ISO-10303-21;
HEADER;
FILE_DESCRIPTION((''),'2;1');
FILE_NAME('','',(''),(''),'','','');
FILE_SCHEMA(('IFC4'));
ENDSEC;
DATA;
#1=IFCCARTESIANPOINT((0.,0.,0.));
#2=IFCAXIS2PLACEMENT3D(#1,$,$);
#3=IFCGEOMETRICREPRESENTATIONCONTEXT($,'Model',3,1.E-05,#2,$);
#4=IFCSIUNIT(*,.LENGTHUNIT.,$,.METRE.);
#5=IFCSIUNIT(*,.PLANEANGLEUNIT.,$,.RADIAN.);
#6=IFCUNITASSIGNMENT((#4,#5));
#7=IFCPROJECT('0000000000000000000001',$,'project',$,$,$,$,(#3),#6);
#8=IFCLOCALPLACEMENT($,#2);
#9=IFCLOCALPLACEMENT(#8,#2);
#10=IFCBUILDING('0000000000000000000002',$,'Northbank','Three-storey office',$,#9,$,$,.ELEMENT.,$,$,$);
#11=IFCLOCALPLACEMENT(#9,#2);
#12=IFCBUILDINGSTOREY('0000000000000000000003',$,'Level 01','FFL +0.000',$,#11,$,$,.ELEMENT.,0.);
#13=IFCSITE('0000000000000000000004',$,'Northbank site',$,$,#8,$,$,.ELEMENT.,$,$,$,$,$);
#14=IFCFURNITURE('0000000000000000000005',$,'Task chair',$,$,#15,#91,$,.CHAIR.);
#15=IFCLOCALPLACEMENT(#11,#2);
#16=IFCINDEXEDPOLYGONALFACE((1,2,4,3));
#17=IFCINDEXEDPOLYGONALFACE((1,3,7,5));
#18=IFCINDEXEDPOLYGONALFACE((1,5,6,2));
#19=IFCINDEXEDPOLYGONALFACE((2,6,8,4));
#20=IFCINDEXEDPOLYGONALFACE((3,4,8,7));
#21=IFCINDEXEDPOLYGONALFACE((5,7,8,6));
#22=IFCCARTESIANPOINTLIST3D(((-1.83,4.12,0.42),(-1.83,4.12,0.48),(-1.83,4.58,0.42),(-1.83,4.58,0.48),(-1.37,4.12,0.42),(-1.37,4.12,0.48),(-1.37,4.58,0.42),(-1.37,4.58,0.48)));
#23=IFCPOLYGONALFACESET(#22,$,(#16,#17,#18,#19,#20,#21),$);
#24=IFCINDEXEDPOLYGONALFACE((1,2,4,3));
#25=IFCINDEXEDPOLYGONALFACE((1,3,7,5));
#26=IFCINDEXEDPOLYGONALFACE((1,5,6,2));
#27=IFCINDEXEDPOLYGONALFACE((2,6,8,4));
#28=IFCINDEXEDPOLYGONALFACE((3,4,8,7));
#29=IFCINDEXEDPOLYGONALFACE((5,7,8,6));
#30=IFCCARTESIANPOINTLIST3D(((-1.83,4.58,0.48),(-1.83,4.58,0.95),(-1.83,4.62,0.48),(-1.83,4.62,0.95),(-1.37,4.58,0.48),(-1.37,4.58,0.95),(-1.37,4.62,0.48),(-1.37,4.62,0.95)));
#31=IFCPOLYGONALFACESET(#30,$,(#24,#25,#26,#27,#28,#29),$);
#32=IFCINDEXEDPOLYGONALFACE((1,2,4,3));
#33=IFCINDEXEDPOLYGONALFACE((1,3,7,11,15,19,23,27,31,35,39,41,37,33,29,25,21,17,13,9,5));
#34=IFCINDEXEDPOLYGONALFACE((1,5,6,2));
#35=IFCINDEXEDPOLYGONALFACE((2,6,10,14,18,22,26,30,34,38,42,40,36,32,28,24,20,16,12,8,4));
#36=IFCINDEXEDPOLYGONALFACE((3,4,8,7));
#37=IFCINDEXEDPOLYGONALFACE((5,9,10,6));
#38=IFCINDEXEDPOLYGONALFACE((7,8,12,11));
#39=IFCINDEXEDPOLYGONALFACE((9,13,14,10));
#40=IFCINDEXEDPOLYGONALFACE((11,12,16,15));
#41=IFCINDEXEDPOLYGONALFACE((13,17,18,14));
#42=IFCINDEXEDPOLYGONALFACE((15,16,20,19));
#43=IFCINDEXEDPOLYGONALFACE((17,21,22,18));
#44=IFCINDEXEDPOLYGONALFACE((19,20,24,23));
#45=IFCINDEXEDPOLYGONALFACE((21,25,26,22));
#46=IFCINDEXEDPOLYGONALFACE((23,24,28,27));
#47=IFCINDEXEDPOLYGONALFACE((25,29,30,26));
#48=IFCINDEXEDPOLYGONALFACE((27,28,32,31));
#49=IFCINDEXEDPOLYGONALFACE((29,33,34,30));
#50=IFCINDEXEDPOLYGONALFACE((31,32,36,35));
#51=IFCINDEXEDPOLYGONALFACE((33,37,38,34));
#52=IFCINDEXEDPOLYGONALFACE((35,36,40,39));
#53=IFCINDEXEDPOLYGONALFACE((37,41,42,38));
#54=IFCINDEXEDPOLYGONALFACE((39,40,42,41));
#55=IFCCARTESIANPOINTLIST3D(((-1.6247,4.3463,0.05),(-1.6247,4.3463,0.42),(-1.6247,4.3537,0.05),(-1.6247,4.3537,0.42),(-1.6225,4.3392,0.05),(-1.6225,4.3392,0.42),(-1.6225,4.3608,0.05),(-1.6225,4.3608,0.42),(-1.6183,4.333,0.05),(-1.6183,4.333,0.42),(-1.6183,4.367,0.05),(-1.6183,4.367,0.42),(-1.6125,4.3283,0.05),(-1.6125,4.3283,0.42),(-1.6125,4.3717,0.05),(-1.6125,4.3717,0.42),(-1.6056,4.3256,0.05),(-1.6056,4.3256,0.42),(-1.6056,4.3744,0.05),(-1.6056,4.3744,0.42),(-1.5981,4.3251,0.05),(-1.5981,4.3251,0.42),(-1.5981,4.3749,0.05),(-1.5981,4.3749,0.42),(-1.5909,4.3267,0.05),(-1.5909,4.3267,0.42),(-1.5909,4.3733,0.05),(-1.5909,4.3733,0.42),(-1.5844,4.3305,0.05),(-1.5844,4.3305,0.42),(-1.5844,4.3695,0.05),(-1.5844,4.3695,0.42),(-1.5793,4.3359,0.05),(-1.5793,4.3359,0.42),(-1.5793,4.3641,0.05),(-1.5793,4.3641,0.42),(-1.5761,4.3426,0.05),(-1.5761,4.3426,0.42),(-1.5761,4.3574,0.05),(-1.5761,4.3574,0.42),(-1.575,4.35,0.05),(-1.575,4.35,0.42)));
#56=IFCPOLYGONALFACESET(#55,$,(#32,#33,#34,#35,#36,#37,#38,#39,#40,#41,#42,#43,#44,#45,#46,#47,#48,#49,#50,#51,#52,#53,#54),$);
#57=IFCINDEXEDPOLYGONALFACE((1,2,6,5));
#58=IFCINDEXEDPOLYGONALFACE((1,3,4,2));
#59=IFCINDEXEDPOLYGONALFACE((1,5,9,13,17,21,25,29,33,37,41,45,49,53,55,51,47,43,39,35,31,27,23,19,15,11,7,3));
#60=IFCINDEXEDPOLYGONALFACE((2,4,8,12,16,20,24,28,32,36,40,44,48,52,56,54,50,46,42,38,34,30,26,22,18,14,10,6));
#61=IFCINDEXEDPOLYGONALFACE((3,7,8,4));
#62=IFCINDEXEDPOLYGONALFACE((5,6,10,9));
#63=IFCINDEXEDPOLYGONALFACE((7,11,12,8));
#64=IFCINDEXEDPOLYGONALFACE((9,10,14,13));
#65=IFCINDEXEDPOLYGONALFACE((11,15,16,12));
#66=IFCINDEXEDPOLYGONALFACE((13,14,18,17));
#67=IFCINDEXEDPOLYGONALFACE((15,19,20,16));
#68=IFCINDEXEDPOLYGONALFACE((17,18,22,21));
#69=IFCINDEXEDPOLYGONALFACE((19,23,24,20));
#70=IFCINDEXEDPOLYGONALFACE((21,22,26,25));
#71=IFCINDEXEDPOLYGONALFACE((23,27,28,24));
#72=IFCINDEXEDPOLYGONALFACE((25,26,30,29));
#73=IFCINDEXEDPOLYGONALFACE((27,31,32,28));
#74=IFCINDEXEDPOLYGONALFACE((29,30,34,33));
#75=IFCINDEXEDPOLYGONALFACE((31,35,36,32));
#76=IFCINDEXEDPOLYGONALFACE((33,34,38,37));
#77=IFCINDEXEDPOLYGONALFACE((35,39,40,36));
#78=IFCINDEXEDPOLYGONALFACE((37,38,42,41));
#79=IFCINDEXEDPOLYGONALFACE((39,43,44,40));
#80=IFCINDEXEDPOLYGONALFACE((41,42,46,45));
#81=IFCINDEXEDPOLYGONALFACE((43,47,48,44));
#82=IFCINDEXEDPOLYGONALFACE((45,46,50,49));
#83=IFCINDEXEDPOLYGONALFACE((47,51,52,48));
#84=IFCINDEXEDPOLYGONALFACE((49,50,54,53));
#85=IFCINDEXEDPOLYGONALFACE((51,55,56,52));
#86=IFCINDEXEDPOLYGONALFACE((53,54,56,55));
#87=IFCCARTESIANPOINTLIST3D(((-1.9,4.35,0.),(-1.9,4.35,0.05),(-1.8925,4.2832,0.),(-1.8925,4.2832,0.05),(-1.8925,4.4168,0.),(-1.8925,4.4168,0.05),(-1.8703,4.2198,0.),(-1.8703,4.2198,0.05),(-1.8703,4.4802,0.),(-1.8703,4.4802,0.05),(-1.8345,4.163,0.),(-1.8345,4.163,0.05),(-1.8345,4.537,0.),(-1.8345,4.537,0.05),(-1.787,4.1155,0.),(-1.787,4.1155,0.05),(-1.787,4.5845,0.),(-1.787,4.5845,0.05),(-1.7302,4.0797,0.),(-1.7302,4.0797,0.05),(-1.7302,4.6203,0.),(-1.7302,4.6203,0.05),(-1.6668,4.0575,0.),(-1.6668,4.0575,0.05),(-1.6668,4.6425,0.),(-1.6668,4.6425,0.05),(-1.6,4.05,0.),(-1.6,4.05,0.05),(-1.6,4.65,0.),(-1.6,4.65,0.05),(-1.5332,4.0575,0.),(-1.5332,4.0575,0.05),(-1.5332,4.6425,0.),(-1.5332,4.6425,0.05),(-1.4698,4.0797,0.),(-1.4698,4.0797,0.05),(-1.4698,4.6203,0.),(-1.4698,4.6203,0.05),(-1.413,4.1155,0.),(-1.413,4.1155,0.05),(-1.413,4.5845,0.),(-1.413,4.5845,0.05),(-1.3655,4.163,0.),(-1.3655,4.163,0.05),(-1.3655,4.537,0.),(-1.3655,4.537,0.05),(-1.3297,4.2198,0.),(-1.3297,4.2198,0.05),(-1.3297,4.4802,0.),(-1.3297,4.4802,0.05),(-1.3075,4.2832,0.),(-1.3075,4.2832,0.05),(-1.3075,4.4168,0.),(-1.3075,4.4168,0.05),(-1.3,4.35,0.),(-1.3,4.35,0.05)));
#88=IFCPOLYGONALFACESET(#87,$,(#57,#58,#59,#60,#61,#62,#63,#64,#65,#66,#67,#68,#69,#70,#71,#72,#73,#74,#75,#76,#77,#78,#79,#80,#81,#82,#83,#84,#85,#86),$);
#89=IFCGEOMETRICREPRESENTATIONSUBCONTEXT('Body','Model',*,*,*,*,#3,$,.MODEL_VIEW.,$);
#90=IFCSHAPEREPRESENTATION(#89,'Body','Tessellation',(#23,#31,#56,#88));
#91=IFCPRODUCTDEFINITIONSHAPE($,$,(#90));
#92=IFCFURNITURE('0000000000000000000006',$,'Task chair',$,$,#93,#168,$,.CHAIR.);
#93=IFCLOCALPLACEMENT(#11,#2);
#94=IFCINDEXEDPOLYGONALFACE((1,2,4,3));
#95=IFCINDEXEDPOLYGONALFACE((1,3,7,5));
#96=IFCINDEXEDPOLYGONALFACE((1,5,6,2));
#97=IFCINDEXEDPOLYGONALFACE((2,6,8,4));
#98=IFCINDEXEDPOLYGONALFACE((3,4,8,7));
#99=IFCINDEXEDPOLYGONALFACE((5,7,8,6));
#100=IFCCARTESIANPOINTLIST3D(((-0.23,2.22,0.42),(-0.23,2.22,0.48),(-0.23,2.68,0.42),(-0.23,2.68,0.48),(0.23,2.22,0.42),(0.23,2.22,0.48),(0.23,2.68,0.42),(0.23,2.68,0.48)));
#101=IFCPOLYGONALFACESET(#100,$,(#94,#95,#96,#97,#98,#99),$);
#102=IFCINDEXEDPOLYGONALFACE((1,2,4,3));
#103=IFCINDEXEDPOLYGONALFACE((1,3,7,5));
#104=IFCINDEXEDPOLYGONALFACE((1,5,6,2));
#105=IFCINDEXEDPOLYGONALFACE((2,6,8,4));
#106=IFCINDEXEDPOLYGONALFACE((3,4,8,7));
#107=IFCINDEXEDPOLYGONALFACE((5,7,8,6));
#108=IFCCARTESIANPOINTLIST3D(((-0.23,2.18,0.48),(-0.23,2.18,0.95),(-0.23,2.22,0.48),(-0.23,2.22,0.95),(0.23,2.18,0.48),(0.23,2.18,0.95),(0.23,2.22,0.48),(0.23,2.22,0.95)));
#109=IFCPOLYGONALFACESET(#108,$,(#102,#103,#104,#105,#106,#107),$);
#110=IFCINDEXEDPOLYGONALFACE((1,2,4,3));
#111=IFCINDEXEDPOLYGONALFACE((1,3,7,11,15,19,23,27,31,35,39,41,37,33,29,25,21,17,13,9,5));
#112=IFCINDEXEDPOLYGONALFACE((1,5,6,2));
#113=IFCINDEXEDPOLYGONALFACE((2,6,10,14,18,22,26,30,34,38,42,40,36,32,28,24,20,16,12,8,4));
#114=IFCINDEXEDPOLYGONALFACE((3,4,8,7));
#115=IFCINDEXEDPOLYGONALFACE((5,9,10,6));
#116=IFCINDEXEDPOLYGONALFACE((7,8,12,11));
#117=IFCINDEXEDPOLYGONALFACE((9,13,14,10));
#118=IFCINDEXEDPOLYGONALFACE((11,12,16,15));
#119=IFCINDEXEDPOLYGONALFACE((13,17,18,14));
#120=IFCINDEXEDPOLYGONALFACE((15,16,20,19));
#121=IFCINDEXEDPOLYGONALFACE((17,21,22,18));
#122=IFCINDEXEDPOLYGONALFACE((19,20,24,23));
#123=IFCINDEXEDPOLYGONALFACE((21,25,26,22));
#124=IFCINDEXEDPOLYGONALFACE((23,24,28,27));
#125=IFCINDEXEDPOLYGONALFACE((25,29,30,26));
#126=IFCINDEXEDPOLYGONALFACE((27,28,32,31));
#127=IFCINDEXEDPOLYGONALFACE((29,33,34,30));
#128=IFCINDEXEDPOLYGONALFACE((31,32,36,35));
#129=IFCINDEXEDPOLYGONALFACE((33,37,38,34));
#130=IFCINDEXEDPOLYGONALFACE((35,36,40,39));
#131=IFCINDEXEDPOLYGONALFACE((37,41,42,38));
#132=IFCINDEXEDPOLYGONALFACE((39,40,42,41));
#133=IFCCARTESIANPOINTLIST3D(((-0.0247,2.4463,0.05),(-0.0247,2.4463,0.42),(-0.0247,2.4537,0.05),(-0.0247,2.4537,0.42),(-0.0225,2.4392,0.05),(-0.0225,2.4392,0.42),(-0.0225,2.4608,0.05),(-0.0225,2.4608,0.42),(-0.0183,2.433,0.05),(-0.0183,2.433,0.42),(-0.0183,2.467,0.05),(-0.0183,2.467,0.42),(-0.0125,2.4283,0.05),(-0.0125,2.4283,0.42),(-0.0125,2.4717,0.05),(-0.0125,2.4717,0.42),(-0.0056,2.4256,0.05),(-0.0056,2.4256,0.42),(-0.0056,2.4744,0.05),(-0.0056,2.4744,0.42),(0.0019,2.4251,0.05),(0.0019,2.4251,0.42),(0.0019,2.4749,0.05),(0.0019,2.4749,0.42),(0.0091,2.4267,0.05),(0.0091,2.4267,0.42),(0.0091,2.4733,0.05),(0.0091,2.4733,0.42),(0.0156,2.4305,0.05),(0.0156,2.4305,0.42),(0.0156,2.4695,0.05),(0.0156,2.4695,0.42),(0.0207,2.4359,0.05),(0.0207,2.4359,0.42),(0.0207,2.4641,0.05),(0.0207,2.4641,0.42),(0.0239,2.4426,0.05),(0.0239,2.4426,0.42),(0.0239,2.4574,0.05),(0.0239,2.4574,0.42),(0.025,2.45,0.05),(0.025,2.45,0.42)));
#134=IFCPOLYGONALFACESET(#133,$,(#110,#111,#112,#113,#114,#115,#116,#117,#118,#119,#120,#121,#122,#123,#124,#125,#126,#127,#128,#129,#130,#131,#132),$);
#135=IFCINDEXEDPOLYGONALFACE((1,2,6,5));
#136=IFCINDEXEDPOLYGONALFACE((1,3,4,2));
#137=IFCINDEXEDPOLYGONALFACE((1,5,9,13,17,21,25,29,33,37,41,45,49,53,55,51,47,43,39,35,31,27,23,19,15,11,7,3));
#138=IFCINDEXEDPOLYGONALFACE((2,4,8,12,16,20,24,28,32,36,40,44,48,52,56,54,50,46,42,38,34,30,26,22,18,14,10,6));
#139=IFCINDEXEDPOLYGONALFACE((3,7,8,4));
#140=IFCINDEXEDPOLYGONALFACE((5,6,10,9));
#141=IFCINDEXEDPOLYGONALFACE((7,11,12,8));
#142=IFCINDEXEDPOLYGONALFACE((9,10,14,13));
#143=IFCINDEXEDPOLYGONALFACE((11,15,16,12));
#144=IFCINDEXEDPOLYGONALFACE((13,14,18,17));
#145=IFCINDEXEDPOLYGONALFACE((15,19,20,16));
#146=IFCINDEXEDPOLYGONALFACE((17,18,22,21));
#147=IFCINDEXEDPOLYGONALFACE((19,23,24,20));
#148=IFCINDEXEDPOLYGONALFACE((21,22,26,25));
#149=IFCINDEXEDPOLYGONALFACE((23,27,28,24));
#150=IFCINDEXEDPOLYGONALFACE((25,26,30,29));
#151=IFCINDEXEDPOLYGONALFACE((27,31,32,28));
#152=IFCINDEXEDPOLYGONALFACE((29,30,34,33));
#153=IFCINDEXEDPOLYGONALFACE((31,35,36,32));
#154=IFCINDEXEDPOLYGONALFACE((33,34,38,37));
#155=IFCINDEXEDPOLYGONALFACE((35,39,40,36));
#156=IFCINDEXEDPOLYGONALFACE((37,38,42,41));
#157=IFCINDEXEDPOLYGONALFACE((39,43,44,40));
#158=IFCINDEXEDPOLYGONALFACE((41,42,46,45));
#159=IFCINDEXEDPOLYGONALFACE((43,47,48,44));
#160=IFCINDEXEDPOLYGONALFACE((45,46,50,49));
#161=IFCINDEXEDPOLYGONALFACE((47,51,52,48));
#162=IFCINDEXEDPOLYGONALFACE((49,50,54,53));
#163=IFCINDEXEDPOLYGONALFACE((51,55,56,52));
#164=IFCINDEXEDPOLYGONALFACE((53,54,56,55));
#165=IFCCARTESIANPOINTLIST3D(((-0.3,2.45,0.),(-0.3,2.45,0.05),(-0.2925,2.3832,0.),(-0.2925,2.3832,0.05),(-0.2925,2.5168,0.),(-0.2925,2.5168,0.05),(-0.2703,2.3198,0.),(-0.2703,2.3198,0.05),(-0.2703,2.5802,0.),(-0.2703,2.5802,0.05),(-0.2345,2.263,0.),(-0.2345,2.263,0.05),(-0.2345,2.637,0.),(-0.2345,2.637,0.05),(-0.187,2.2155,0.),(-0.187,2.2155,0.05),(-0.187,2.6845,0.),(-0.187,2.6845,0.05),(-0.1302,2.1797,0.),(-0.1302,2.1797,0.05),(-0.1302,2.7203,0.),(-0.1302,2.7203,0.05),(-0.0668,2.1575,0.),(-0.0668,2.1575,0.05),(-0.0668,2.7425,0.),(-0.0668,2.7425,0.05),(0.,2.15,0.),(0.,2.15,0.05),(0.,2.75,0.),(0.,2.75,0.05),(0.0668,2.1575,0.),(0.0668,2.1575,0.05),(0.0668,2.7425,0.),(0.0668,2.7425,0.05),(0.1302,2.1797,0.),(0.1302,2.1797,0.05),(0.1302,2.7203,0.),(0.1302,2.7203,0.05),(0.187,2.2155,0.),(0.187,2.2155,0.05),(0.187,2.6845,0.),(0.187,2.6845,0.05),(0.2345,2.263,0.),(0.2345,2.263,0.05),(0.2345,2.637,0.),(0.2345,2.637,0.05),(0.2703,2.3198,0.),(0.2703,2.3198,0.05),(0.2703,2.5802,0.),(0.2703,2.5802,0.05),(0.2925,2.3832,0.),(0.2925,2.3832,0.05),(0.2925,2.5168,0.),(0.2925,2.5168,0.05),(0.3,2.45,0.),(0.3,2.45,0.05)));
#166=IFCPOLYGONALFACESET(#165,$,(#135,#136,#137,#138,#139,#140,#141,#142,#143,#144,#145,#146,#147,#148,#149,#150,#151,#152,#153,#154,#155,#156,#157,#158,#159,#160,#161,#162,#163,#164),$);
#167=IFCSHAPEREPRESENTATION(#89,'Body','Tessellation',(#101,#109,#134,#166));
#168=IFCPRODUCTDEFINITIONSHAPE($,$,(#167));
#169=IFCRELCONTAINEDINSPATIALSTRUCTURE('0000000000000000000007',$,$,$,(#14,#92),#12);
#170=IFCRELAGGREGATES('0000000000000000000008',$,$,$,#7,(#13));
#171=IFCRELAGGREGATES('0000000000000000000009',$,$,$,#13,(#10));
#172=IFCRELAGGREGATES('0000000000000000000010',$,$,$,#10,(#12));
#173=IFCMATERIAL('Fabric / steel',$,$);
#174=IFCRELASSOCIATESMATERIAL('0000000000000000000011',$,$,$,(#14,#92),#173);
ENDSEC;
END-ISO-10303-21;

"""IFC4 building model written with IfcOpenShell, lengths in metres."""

from ifc_helpers import new_model, si_unit, frame, origin, place, context, subcontext, project, spatial, rectangle, circle, extrude, material, element, save


model = new_model("IFC4")

# Units and contexts
model_context = context("Model", 3, precision=1e-05, world=origin())
body_context = subcontext(model_context, "Body", "Model", "MODEL_VIEW")
ifc_project = project(units=[si_unit("LENGTHUNIT", "METRE"), si_unit("PLANEANGLEUNIT", "RADIAN")], contexts=[model_context])

# Site, building, storey
site_placement = place(None, origin())
site = spatial("IfcSite", under=ifc_project, at=site_placement, Name="Northbank site", CompositionType="ELEMENT")
building_placement = place(site_placement, origin())
building = spatial("IfcBuilding", under=site, at=building_placement, Name="Northbank", Description="Three-storey office", CompositionType="ELEMENT")
storey_placement = place(building_placement, origin())
storey = spatial("IfcBuildingStorey", under=building, at=storey_placement, Name="Level 01", Description="FFL +0.000", CompositionType="ELEMENT", Elevation=0.0)

# Furniture
ifc_material_1 = material(Name="Fabric / steel")
furniture_1_placement = place(storey_placement, origin())
element("IfcFurniture", 1, at=furniture_1_placement, inside=storey, material=ifc_material_1, Name="Task chair", PredefinedType="CHAIR", context=body_context, shape_type="SweptSolid", body=[
    extrude(rectangle(XDim=0.46, YDim=0.46), frame((-1.6, 4.35, 0.42)), (0.0, 0.0, 1.0), 0.06),
    extrude(rectangle(XDim=0.46, YDim=0.04), frame((-1.6, 4.6, 0.48)), (0.0, 0.0, 1.0), 0.47),
    extrude(circle(Radius=0.025), frame((-1.6, 4.35, 0.05), z_axis=(0.0, 0.0, 1.0), x_axis=(1.0, 0.0, 0.0)), (0.0, 0.0, 1.0), 0.37),
    extrude(circle(Radius=0.3), frame((-1.6, 4.35, 0.0), z_axis=(0.0, 0.0, 1.0), x_axis=(1.0, 0.0, 0.0)), (0.0, 0.0, 1.0), 0.05),
])
furniture_2_placement = place(storey_placement, origin())
element("IfcFurniture", 2, at=furniture_2_placement, inside=storey, material=ifc_material_1, Name="Task chair", PredefinedType="CHAIR", context=body_context, shape_type="SweptSolid", body=[
    extrude(rectangle(XDim=0.46, YDim=0.46), frame((0.0, 2.45, 0.42)), (0.0, 0.0, 1.0), 0.06),
    extrude(rectangle(XDim=0.46, YDim=0.04), frame((0.0, 2.2, 0.48)), (0.0, 0.0, 1.0), 0.47),
    extrude(circle(Radius=0.025), frame((0.0, 2.45, 0.05), z_axis=(0.0, 0.0, 1.0), x_axis=(1.0, 0.0, 0.0)), (0.0, 0.0, 1.0), 0.37),
    extrude(circle(Radius=0.3), frame((0.0, 2.45, 0.0), z_axis=(0.0, 0.0, 1.0), x_axis=(1.0, 0.0, 0.0)), (0.0, 0.0, 1.0), 0.05),
])

save(model, "model.ifc")
